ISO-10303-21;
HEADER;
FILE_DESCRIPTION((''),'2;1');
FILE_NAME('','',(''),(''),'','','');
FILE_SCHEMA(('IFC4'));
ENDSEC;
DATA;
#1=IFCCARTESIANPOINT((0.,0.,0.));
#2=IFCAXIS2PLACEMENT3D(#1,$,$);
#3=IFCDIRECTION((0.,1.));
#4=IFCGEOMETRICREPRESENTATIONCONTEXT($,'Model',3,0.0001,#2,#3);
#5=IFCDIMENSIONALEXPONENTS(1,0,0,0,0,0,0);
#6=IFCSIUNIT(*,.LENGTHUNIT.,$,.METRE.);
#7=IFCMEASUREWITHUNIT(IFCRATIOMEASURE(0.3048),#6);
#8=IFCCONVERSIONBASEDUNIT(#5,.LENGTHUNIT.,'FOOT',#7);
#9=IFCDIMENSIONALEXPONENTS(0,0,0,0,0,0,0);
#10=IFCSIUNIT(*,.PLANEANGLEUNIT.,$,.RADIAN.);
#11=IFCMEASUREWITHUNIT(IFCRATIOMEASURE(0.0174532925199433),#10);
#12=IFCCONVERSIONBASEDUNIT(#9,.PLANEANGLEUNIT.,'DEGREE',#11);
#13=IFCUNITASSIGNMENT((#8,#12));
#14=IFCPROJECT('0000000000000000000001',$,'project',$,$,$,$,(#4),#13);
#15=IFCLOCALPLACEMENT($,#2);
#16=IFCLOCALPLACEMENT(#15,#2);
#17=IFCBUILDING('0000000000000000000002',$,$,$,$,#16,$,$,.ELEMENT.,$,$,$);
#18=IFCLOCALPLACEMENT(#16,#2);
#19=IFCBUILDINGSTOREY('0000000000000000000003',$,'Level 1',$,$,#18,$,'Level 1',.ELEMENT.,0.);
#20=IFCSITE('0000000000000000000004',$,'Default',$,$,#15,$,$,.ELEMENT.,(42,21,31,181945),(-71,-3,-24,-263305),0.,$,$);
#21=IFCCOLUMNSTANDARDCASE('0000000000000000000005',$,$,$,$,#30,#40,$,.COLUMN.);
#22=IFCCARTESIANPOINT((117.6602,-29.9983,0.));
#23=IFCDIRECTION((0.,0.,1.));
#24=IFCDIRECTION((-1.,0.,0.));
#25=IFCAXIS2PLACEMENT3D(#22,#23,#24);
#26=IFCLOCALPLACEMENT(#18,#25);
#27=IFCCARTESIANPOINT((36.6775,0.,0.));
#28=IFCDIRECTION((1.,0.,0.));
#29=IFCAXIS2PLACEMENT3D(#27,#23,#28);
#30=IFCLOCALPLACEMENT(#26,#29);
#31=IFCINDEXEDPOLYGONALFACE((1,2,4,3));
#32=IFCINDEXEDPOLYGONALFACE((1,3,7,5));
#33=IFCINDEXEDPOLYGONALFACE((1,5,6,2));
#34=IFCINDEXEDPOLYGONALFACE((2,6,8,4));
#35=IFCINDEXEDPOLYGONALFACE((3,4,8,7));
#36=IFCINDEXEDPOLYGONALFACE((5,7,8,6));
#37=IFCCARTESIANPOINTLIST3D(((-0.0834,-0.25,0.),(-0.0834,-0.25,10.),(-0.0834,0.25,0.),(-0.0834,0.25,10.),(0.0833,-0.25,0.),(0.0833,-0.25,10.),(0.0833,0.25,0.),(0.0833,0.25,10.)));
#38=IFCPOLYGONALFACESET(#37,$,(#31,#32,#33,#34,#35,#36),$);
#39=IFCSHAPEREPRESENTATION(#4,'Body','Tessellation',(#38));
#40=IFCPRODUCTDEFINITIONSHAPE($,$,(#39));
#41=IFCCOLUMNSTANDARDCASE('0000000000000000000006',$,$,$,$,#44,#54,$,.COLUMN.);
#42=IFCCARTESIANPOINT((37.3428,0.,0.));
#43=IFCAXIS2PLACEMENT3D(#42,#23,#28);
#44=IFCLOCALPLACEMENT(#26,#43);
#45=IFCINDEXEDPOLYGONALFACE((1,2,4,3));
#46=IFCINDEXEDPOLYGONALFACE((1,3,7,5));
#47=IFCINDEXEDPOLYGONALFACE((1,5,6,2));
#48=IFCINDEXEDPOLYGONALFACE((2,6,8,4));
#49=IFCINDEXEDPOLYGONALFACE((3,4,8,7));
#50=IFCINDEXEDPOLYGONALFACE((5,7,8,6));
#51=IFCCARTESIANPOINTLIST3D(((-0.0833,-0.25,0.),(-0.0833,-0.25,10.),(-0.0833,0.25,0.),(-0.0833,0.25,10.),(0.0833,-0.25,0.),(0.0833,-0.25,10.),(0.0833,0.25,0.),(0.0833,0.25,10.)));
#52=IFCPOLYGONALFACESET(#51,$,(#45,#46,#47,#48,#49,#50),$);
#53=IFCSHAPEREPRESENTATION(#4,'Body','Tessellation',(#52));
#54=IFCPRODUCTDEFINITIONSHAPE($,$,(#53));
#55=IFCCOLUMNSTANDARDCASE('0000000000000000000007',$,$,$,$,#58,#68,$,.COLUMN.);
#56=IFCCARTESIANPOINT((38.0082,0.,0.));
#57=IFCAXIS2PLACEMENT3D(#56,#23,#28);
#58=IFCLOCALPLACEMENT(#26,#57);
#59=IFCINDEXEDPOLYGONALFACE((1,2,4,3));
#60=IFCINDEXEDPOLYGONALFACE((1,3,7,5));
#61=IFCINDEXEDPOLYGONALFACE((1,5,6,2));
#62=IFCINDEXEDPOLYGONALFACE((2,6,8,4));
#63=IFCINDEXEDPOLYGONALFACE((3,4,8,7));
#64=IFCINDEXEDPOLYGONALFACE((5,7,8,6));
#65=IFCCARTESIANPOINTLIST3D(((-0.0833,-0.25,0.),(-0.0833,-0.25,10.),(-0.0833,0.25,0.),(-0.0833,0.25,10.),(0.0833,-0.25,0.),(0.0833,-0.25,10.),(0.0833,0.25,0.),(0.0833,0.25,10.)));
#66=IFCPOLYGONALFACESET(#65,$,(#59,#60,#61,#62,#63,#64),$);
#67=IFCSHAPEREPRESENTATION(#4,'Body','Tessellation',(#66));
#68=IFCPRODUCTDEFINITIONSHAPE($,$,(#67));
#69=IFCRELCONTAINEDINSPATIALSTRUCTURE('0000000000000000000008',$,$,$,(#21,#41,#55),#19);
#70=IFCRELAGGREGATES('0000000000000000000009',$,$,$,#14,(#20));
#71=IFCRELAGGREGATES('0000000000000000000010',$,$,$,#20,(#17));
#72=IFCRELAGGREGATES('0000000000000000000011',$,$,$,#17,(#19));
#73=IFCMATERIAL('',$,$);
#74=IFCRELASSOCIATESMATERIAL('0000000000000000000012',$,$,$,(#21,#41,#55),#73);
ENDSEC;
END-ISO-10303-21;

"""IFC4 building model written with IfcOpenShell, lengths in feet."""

from ifc_helpers import new_model, entity, si_unit, converted_unit, direction, frame, origin, place, context, project, spatial, rectangle, extrude, material, element, save


model = new_model("IFC4")

# Units and contexts
model_context = context("Model", 3, precision=0.0001, world=origin(), true_north=direction((0.0, 1.0)))
ifc_project = project(units=[converted_unit("LENGTHUNIT", "FOOT", entity("IfcRatioMeasure", 0.3048), si_unit("LENGTHUNIT", "METRE"), dimensions=[1, 0, 0, 0, 0, 0, 0]), converted_unit("PLANEANGLEUNIT", "DEGREE", entity("IfcRatioMeasure", 0.0174532925199433), si_unit("PLANEANGLEUNIT", "RADIAN"), dimensions=[0, 0, 0, 0, 0, 0, 0])], contexts=[model_context])

# Site, building, storey
site_placement = place(None, origin())
site = spatial("IfcSite", under=ifc_project, at=site_placement, Name="Default", CompositionType="ELEMENT", RefLatitude=(42, 21, 31, 181945), RefLongitude=(-71, -3, -24, -263305), RefElevation=0.0)
building_placement = place(site_placement, origin())
building = spatial("IfcBuilding", under=site, at=building_placement, CompositionType="ELEMENT")
storey_placement = place(building_placement, origin())
storey = spatial("IfcBuildingStorey", under=building, at=storey_placement, Name="Level 1", LongName="Level 1", CompositionType="ELEMENT", Elevation=0.0)

# Columns
ifc_material = material(Name="")
placement = place(storey_placement, frame((117.6602, -29.9983, 0.0), z_axis=(0.0, 0.0, 1.0), x_axis=(-1.0, 0.0, 0.0)))
for number, where, z_axis, x_axis in (
    (1, (36.6775, 0.0, 0.0), (0.0, 0.0, 1.0), (1.0, 0.0, 0.0)),
    (2, (37.3428, 0.0, 0.0), (0.0, 0.0, 1.0), (1.0, 0.0, 0.0)),
    (3, (38.0082, 0.0, 0.0), (0.0, 0.0, 1.0), (1.0, 0.0, 0.0)),
):
    element("IfcColumnStandardCase", number, at=place(placement, frame(where, z_axis=z_axis, x_axis=x_axis)), inside=storey, material=ifc_material, PredefinedType="COLUMN", context=model_context, shape_type="SweptSolid", body=[
        extrude(rectangle(XDim=0.1667, YDim=0.5), origin(), (0.0, 0.0, 1.0), 10.0),
    ])

save(model, "model.ifc")
